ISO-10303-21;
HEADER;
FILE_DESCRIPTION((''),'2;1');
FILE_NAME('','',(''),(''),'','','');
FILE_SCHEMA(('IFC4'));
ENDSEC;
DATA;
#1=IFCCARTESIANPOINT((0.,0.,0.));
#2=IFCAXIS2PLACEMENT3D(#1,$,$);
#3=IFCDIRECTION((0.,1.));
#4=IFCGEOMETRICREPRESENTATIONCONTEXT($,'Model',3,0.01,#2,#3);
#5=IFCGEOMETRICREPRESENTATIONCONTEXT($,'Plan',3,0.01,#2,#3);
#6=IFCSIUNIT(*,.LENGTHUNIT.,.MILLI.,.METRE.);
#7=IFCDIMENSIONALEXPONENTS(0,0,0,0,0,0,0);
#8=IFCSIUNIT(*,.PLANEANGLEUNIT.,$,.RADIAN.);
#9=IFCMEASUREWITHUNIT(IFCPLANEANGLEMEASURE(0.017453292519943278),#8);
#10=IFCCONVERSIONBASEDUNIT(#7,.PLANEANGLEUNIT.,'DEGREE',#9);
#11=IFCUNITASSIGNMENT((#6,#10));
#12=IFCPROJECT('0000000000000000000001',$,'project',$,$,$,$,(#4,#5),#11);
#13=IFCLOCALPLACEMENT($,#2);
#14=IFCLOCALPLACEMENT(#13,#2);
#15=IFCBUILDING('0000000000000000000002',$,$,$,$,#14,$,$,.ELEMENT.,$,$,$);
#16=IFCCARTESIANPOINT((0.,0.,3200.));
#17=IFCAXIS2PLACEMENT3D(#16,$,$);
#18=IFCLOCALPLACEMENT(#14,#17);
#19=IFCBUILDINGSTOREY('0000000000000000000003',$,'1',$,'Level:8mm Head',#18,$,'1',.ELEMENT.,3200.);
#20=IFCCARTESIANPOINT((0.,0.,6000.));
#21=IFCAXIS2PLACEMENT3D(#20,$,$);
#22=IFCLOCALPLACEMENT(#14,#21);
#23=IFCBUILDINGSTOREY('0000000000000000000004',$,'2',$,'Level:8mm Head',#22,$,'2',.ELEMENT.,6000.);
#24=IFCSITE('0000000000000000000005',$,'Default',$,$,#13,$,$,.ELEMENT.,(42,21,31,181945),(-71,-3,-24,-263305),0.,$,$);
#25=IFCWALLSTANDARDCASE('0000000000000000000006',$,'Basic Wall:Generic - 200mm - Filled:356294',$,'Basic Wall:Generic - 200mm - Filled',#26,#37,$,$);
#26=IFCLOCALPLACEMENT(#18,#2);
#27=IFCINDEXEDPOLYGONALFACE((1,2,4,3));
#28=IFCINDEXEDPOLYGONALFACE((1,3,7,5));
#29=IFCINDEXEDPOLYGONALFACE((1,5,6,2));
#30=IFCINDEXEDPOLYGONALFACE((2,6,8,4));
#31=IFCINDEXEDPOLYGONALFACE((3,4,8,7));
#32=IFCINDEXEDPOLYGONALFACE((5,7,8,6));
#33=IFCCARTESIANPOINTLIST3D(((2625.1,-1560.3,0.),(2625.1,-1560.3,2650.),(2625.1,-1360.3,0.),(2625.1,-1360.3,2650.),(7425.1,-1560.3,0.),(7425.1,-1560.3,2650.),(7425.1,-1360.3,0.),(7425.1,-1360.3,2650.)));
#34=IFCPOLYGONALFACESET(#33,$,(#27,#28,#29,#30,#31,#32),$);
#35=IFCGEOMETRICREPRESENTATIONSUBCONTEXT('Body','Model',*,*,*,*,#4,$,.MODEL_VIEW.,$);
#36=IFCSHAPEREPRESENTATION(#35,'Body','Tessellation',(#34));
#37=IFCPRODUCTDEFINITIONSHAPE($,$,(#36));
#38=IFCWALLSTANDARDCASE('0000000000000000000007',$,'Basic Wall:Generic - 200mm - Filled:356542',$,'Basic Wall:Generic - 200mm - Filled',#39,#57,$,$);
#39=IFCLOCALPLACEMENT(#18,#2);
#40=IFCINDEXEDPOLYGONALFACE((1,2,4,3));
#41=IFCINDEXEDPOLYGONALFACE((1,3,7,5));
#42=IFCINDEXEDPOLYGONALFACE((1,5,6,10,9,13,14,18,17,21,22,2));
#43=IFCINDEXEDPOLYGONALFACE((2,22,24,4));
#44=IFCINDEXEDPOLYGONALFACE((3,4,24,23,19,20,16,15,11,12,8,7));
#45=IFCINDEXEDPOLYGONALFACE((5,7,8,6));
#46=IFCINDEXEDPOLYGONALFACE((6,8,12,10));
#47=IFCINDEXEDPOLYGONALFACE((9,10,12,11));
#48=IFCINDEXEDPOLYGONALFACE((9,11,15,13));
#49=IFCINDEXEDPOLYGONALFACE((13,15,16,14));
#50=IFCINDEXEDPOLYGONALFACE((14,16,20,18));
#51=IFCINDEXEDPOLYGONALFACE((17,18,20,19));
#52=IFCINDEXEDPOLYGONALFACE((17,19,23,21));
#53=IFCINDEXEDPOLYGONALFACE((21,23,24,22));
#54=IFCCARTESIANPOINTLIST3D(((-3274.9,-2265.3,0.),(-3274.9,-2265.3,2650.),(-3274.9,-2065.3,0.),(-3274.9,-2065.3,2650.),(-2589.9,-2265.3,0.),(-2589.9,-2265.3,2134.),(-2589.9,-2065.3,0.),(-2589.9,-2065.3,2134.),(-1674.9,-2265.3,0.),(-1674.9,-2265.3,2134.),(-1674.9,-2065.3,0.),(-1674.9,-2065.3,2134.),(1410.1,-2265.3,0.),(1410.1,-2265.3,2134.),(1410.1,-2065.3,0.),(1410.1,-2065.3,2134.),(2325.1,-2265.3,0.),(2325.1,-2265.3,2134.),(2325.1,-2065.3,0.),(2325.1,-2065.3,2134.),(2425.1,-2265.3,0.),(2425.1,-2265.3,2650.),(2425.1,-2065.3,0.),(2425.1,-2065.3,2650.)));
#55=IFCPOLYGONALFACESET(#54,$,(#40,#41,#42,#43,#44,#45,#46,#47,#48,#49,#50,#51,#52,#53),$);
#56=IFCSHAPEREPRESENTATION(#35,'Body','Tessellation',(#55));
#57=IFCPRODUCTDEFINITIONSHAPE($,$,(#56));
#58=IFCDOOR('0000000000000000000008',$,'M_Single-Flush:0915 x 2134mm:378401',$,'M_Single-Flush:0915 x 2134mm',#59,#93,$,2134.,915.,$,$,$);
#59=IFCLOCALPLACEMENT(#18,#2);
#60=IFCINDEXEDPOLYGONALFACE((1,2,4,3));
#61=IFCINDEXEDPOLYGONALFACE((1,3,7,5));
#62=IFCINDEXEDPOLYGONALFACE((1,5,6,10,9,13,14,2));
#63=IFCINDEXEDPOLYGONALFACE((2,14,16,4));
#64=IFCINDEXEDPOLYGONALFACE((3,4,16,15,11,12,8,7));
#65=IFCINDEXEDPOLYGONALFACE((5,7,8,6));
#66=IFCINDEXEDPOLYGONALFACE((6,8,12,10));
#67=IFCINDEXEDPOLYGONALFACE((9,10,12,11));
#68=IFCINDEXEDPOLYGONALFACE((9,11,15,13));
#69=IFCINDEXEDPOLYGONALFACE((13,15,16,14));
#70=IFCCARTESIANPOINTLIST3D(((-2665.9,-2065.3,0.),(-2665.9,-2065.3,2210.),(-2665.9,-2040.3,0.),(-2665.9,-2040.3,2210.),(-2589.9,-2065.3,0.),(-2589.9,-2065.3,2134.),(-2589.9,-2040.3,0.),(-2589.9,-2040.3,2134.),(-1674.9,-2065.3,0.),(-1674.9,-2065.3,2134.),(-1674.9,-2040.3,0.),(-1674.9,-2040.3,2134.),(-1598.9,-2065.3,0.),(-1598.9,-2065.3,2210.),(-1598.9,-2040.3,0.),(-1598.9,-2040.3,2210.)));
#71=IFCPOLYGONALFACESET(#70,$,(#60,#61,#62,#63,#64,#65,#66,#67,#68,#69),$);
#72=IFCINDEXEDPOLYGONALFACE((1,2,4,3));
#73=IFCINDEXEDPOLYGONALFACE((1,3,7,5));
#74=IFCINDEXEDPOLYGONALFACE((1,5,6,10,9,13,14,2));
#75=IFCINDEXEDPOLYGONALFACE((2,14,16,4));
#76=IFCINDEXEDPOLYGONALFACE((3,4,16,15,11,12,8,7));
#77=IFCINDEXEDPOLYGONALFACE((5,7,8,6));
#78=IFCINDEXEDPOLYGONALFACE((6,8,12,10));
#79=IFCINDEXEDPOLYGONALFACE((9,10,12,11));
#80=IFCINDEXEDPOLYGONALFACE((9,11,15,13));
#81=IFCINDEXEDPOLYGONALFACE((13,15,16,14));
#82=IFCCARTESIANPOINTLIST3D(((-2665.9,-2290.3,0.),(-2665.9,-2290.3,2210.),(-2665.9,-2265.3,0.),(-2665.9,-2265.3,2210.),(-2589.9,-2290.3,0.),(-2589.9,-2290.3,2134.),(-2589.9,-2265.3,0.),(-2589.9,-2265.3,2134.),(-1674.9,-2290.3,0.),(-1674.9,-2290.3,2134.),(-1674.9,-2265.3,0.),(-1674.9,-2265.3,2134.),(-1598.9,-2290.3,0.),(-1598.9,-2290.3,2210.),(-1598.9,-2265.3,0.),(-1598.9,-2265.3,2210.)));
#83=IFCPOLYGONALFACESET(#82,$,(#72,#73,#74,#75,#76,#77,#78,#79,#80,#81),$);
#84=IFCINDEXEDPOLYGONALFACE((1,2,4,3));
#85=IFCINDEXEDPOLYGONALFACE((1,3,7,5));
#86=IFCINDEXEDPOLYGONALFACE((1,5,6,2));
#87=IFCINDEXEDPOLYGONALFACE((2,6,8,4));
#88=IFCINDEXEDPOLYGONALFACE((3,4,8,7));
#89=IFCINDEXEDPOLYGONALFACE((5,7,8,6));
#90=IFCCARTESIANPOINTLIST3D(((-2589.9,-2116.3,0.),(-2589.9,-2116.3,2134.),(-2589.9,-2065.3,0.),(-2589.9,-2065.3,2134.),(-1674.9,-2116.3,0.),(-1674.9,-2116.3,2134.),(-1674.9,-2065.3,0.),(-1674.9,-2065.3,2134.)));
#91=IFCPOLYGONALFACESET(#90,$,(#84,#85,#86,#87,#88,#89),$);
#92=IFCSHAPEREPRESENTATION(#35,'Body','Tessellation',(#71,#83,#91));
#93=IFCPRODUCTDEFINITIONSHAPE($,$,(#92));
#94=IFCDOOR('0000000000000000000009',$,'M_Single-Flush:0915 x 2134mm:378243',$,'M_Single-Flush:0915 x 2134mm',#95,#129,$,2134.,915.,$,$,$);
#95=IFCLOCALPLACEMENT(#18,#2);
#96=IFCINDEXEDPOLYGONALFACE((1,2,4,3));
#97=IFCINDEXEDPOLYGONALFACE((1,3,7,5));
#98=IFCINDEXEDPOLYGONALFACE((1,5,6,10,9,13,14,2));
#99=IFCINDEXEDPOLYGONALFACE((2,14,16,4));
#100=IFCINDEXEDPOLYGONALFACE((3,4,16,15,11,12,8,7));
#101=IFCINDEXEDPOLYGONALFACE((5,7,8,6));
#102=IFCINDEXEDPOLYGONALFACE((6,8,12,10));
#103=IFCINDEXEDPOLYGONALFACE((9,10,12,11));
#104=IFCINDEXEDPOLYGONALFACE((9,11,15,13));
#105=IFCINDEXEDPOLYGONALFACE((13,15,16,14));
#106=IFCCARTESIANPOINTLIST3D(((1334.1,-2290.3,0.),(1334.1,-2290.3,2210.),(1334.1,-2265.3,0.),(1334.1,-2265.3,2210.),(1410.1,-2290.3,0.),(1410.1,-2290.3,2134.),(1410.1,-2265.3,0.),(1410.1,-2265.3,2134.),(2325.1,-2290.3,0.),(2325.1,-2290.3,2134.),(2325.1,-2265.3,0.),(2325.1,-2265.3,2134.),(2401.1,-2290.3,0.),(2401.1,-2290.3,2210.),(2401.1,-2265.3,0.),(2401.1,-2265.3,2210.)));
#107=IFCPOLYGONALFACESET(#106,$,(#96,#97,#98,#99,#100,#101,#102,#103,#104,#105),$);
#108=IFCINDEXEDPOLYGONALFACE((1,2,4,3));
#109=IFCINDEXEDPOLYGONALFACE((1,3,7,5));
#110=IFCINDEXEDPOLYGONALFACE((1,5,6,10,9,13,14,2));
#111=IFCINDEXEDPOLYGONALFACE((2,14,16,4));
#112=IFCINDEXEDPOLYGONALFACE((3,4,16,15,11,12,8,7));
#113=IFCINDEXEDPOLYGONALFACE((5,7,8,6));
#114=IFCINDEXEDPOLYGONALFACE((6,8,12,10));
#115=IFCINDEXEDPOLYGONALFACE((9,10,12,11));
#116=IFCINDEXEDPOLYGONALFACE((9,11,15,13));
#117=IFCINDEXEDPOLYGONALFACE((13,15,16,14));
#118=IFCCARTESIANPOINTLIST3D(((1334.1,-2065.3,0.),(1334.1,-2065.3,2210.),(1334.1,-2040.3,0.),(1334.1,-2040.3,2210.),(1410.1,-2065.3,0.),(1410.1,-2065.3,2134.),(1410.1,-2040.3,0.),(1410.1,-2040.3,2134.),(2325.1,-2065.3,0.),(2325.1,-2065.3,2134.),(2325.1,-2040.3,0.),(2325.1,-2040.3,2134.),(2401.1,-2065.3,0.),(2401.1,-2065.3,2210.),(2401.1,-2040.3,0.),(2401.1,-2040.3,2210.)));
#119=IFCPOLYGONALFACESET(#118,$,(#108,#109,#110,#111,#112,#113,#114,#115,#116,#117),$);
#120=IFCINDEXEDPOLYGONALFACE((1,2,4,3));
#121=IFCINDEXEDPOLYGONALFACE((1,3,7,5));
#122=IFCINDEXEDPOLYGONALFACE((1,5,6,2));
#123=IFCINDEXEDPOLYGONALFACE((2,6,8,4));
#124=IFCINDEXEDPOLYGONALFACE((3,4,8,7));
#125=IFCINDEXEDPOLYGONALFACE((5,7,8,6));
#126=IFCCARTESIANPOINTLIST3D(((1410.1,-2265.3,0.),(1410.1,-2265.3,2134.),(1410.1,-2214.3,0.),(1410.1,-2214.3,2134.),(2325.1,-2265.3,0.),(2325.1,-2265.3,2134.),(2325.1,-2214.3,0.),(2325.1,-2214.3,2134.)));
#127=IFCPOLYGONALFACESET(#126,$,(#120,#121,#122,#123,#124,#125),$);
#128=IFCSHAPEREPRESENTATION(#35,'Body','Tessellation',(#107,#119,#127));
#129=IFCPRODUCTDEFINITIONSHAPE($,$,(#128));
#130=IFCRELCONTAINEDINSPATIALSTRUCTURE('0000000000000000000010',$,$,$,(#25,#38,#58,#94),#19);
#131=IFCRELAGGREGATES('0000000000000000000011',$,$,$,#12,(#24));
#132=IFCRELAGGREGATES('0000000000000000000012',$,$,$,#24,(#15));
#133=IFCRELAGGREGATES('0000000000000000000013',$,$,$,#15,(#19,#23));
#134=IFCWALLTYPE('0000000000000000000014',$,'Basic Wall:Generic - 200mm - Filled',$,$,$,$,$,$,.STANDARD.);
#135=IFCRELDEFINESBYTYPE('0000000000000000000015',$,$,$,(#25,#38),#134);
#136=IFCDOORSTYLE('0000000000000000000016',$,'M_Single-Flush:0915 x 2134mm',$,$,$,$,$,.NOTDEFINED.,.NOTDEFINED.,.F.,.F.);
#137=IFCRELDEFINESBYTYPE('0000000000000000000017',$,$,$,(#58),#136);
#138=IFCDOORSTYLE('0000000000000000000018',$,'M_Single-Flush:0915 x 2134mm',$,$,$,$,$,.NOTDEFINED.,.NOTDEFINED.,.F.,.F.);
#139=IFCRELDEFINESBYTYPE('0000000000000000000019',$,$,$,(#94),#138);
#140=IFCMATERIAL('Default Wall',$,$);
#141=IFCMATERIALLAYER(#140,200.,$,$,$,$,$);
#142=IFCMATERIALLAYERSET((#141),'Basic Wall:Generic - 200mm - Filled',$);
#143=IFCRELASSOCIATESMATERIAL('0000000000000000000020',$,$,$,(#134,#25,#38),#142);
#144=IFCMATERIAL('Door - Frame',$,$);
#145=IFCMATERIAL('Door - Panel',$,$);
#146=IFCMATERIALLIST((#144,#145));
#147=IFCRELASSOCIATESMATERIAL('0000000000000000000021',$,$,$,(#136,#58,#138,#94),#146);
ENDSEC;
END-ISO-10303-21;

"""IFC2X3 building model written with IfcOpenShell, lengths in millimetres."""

from ifc_helpers import new_model, entity, si_unit, converted_unit, direction, frame, frame_2d, origin, place, context, subcontext, project, spatial, polyline, rectangle, outline, extrude, clip, bounded_halfspace, source, transform, mapped, material, material_list, layer, layer_set, layer_usage, type_object, type_shapes, element, fill, save


model = new_model("IFC2X3")

# Units and contexts
model_context = context("Model", 3, precision=0.01, world=origin(), true_north=direction((0.0, 1.0)))
plan_context = context("Plan", 3, precision=0.01, world=origin(), true_north=direction((0.0, 1.0)))
body_context = subcontext(model_context, "Body", "Model", "MODEL_VIEW")
ifc_project = project(units=[si_unit("LENGTHUNIT", "METRE", prefix="MILLI"), converted_unit("PLANEANGLEUNIT", "DEGREE", entity("IfcPlaneAngleMeasure", 0.017453292519943278), si_unit("PLANEANGLEUNIT", "RADIAN"), dimensions=[0, 0, 0, 0, 0, 0, 0])], contexts=[model_context, plan_context])

# Site, building, storey
site_placement = place(None, origin())
site = spatial("IfcSite", under=ifc_project, at=site_placement, Name="Default", CompositionType="ELEMENT", RefLatitude=(42, 21, 31, 181945), RefLongitude=(-71, -3, -24, -263305), RefElevation=0.0)
building_placement = place(site_placement, origin())
building = spatial("IfcBuilding", under=site, at=building_placement, CompositionType="ELEMENT")
storey_1_placement = place(building_placement, frame((0.0, 0.0, 3200.0)))
storey_1 = spatial("IfcBuildingStorey", under=building, at=storey_1_placement, Name="1", ObjectType="Level:8mm Head", LongName="1", CompositionType="ELEMENT", Elevation=3200.0)

# Shared definitions
ifc_material_1 = material(Name="Default Wall")

# Shared definitions
storey_2_placement = place(building_placement, frame((0.0, 0.0, 6000.0)))
storey_2 = spatial("IfcBuildingStorey", under=building, at=storey_2_placement, Name="2", ObjectType="Level:8mm Head", LongName="2", CompositionType="ELEMENT", Elevation=6000.0)

# Wall
ifc_layer_1 = layer(ifc_material_1, 200.0)
ifc_layer_set_1 = layer_set([ifc_layer_1], Name="Basic Wall:Generic - 200mm - Filled")
ifc_layer_usage_1 = layer_usage(ifc_layer_set_1, "AXIS2", "NEGATIVE", 100.0)
wall_type_1 = type_object("IfcWallType", Name="Basic Wall:Generic - 200mm - Filled", PredefinedType="STANDARD", material=ifc_layer_set_1)
wall_1_placement = place(storey_1_placement, frame((2625.1, -1460.3, 0.0)))
element("IfcWallStandardCase", 1, at=wall_1_placement, inside=storey_1, type_object=wall_type_1, material=ifc_layer_usage_1, Name="Basic Wall:Generic - 200mm - Filled:356294", ObjectType="Basic Wall:Generic - 200mm - Filled", context=body_context, shape_type="Clipping", body=[
    clip(extrude(rectangle(XDim=4800.0, YDim=200.0, at=frame_2d((2400.0, 0.0), x_axis=(-1.0, 0.0))), origin(), (0.0, 0.0, 1.0), 2650.0), bounded_halfspace(frame((0.0, -100.0, 2650.0), z_axis=(0.0, 0.0, -1.0), x_axis=(0.0, -1.0, 0.0)), True, frame((0.0, -100.0, 2650.0)), polyline([(0.0, 0.0), (4800.0, 0.0), (4800.0, 200.0), (0.0, 200.0), (0.0, 0.0)]))),
])

# Wall, openings, doors
wall_2_placement = place(storey_1_placement, frame((2425.1, -2165.3, 0.0), z_axis=(0.0, 0.0, 1.0), x_axis=(-1.0, 0.0, 0.0)))
wall_2 = element("IfcWallStandardCase", 2, at=wall_2_placement, inside=storey_1, type_object=wall_type_1, material=ifc_layer_usage_1, Name="Basic Wall:Generic - 200mm - Filled:356542", ObjectType="Basic Wall:Generic - 200mm - Filled", context=body_context, shape_type="Clipping", body=[
    clip(extrude(rectangle(XDim=5700.0, YDim=200.0, at=frame_2d((2850.0, 0.0), x_axis=(-1.0, 0.0))), origin(), (0.0, 0.0, 1.0), 2650.0), bounded_halfspace(frame((0.0, -100.0, 2650.0), z_axis=(0.0, 0.0, -1.0), x_axis=(0.0, 1.0, 0.0)), True, frame((0.0, -100.0, 2650.0)), polyline([(0.0, 0.0), (5700.0, 0.0), (5700.0, 200.0), (3400.0, 200.0), (3200.0, 200.0), (1200.0, 200.0), (1100.0, 200.0), (0.0, 200.0), (0.0, 0.0)]))),
])
opening_1_placement = place(wall_2_placement, frame((100.0, -100.0, 0.0)))
opening_1 = element("IfcOpeningElement", 3, at=opening_1_placement, cuts=wall_2, ObjectType="Opening", context=body_context, shape_type="SweptSolid", body=[
    extrude(rectangle(XDim=915.0, YDim=2134.0, at=frame_2d((1067.0, 457.5), x_axis=(0.0, 1.0))), frame((0.0, 0.0, 0.0), z_axis=(0.0, 1.0, 0.0), x_axis=(0.0, 0.0, 1.0)), (0.0, 0.0, 1.0), 200.0),
])
opening_2_placement = place(wall_2_placement, frame((5015.0, 100.0, 0.0)))
opening_2 = element("IfcOpeningElement", 4, at=opening_2_placement, cuts=wall_2, ObjectType="Opening", context=body_context, shape_type="SweptSolid", body=[
    extrude(rectangle(XDim=915.0, YDim=2134.0, at=frame_2d((1067.0, 457.5), x_axis=(0.0, -1.0))), frame((0.0, 0.0, 0.0), z_axis=(0.0, -1.0, 0.0), x_axis=(0.0, 0.0, 1.0)), (0.0, 0.0, 1.0), 200.0),
])
ifc_material_2 = material(Name="Door - Frame")
ifc_material_3 = material(Name="Door - Panel")
ifc_material_list_1 = material_list([ifc_material_2, ifc_material_3])
door_style_1 = type_object("IfcDoorStyle", Name="M_Single-Flush:0915 x 2134mm", ConstructionType="NOTDEFINED", OperationType="NOTDEFINED", ParameterTakesPrecedence=False, Sizeable=False, material=ifc_material_list_1)
shared_shape_1 = source(origin(), body_context, "Body", "SweptSolid", [
    extrude(outline(polyline([(-533.5, -1124.0), (533.5, -1124.0), (533.5, 1086.0), (457.5, 1086.0), (457.5, -1048.0), (-457.5, -1048.0), (-457.5, 1086.0), (-533.5, 1086.0), (-533.5, -1124.0)])), frame((457.5, 225.0, 1086.0), z_axis=(0.0, -1.0, 0.0), x_axis=(-1.0, 0.0, 0.0)), (0.0, 0.0, 1.0), 25.0),
    extrude(outline(polyline([(-1124.0, -533.5), (1086.0, -533.5), (1086.0, -457.5), (-1048.0, -457.5), (-1048.0, 457.5), (1086.0, 457.5), (1086.0, 533.5), (-1124.0, 533.5), (-1124.0, -533.5)])), frame((457.5, 0.0, 1086.0), z_axis=(0.0, -1.0, 0.0), x_axis=(0.0, 0.0, -1.0)), (0.0, 0.0, 1.0), 25.0),
    extrude(rectangle(XDim=915.0, YDim=51.0, at=frame_2d((0.0, 0.0), x_axis=(1.0, 0.0))), frame((457.5, 174.5, 0.0)), (0.0, 0.0, 1.0), 2134.0),
])
type_shapes(door_style_1, [shared_shape_1])
door_1_placement = place(opening_2_placement, frame((0.0, 0.0, 0.0), z_axis=(0.0, 0.0, 1.0), x_axis=(-1.0, 0.0, 0.0)))
door_1 = element("IfcDoor", 5, at=door_1_placement, inside=storey_1, type_object=door_style_1, material=ifc_material_list_1, Name="M_Single-Flush:0915 x 2134mm:378401", ObjectType="M_Single-Flush:0915 x 2134mm", OverallHeight=2134.0, OverallWidth=915.0, context=body_context, shape_type="MappedRepresentation", body=[
    mapped(shared_shape_1, transform((0.0, 0.0, 0.0), scale=1.0)),
])
fill(opening_2, door_1)
door_style_2 = type_object("IfcDoorStyle", Name="M_Single-Flush:0915 x 2134mm", ConstructionType="NOTDEFINED", OperationType="NOTDEFINED", ParameterTakesPrecedence=False, Sizeable=False, material=ifc_material_list_1)
shared_shape_2 = source(origin(), body_context, "Body", "SweptSolid", [
    extrude(outline(polyline([(-533.5, -1124.0), (533.5, -1124.0), (533.5, 1086.0), (457.5, 1086.0), (457.5, -1048.0), (-457.5, -1048.0), (-457.5, 1086.0), (-533.5, 1086.0), (-533.5, -1124.0)])), frame((457.5, 200.0, 1086.0), z_axis=(0.0, 1.0, 0.0), x_axis=(1.0, 0.0, 0.0)), (0.0, 0.0, 1.0), 25.0),
    extrude(outline(polyline([(-1124.0, -533.5), (1086.0, -533.5), (1086.0, -457.5), (-1048.0, -457.5), (-1048.0, 457.5), (1086.0, 457.5), (1086.0, 533.5), (-1124.0, 533.5), (-1124.0, -533.5)])), frame((457.5, -25.0, 1086.0), z_axis=(0.0, 1.0, 0.0), x_axis=(0.0, 0.0, -1.0)), (0.0, 0.0, 1.0), 25.0),
    extrude(rectangle(XDim=51.0, YDim=915.0, at=frame_2d((0.0, 0.0), x_axis=(1.0, 0.0))), frame((457.5, 174.5, 0.0), z_axis=(0.0, 0.0, 1.0), x_axis=(0.0, 1.0, 0.0)), (0.0, 0.0, 1.0), 2134.0),
])
type_shapes(door_style_2, [shared_shape_2])
door_2_placement = place(opening_1_placement, origin())
door_2 = element("IfcDoor", 6, at=door_2_placement, inside=storey_1, type_object=door_style_2, material=ifc_material_list_1, Name="M_Single-Flush:0915 x 2134mm:378243", ObjectType="M_Single-Flush:0915 x 2134mm", OverallHeight=2134.0, OverallWidth=915.0, context=body_context, shape_type="MappedRepresentation", body=[
    mapped(shared_shape_2, transform((0.0, 0.0, 0.0), scale=1.0)),
])
fill(opening_1, door_2)

save(model, "model.ifc")
